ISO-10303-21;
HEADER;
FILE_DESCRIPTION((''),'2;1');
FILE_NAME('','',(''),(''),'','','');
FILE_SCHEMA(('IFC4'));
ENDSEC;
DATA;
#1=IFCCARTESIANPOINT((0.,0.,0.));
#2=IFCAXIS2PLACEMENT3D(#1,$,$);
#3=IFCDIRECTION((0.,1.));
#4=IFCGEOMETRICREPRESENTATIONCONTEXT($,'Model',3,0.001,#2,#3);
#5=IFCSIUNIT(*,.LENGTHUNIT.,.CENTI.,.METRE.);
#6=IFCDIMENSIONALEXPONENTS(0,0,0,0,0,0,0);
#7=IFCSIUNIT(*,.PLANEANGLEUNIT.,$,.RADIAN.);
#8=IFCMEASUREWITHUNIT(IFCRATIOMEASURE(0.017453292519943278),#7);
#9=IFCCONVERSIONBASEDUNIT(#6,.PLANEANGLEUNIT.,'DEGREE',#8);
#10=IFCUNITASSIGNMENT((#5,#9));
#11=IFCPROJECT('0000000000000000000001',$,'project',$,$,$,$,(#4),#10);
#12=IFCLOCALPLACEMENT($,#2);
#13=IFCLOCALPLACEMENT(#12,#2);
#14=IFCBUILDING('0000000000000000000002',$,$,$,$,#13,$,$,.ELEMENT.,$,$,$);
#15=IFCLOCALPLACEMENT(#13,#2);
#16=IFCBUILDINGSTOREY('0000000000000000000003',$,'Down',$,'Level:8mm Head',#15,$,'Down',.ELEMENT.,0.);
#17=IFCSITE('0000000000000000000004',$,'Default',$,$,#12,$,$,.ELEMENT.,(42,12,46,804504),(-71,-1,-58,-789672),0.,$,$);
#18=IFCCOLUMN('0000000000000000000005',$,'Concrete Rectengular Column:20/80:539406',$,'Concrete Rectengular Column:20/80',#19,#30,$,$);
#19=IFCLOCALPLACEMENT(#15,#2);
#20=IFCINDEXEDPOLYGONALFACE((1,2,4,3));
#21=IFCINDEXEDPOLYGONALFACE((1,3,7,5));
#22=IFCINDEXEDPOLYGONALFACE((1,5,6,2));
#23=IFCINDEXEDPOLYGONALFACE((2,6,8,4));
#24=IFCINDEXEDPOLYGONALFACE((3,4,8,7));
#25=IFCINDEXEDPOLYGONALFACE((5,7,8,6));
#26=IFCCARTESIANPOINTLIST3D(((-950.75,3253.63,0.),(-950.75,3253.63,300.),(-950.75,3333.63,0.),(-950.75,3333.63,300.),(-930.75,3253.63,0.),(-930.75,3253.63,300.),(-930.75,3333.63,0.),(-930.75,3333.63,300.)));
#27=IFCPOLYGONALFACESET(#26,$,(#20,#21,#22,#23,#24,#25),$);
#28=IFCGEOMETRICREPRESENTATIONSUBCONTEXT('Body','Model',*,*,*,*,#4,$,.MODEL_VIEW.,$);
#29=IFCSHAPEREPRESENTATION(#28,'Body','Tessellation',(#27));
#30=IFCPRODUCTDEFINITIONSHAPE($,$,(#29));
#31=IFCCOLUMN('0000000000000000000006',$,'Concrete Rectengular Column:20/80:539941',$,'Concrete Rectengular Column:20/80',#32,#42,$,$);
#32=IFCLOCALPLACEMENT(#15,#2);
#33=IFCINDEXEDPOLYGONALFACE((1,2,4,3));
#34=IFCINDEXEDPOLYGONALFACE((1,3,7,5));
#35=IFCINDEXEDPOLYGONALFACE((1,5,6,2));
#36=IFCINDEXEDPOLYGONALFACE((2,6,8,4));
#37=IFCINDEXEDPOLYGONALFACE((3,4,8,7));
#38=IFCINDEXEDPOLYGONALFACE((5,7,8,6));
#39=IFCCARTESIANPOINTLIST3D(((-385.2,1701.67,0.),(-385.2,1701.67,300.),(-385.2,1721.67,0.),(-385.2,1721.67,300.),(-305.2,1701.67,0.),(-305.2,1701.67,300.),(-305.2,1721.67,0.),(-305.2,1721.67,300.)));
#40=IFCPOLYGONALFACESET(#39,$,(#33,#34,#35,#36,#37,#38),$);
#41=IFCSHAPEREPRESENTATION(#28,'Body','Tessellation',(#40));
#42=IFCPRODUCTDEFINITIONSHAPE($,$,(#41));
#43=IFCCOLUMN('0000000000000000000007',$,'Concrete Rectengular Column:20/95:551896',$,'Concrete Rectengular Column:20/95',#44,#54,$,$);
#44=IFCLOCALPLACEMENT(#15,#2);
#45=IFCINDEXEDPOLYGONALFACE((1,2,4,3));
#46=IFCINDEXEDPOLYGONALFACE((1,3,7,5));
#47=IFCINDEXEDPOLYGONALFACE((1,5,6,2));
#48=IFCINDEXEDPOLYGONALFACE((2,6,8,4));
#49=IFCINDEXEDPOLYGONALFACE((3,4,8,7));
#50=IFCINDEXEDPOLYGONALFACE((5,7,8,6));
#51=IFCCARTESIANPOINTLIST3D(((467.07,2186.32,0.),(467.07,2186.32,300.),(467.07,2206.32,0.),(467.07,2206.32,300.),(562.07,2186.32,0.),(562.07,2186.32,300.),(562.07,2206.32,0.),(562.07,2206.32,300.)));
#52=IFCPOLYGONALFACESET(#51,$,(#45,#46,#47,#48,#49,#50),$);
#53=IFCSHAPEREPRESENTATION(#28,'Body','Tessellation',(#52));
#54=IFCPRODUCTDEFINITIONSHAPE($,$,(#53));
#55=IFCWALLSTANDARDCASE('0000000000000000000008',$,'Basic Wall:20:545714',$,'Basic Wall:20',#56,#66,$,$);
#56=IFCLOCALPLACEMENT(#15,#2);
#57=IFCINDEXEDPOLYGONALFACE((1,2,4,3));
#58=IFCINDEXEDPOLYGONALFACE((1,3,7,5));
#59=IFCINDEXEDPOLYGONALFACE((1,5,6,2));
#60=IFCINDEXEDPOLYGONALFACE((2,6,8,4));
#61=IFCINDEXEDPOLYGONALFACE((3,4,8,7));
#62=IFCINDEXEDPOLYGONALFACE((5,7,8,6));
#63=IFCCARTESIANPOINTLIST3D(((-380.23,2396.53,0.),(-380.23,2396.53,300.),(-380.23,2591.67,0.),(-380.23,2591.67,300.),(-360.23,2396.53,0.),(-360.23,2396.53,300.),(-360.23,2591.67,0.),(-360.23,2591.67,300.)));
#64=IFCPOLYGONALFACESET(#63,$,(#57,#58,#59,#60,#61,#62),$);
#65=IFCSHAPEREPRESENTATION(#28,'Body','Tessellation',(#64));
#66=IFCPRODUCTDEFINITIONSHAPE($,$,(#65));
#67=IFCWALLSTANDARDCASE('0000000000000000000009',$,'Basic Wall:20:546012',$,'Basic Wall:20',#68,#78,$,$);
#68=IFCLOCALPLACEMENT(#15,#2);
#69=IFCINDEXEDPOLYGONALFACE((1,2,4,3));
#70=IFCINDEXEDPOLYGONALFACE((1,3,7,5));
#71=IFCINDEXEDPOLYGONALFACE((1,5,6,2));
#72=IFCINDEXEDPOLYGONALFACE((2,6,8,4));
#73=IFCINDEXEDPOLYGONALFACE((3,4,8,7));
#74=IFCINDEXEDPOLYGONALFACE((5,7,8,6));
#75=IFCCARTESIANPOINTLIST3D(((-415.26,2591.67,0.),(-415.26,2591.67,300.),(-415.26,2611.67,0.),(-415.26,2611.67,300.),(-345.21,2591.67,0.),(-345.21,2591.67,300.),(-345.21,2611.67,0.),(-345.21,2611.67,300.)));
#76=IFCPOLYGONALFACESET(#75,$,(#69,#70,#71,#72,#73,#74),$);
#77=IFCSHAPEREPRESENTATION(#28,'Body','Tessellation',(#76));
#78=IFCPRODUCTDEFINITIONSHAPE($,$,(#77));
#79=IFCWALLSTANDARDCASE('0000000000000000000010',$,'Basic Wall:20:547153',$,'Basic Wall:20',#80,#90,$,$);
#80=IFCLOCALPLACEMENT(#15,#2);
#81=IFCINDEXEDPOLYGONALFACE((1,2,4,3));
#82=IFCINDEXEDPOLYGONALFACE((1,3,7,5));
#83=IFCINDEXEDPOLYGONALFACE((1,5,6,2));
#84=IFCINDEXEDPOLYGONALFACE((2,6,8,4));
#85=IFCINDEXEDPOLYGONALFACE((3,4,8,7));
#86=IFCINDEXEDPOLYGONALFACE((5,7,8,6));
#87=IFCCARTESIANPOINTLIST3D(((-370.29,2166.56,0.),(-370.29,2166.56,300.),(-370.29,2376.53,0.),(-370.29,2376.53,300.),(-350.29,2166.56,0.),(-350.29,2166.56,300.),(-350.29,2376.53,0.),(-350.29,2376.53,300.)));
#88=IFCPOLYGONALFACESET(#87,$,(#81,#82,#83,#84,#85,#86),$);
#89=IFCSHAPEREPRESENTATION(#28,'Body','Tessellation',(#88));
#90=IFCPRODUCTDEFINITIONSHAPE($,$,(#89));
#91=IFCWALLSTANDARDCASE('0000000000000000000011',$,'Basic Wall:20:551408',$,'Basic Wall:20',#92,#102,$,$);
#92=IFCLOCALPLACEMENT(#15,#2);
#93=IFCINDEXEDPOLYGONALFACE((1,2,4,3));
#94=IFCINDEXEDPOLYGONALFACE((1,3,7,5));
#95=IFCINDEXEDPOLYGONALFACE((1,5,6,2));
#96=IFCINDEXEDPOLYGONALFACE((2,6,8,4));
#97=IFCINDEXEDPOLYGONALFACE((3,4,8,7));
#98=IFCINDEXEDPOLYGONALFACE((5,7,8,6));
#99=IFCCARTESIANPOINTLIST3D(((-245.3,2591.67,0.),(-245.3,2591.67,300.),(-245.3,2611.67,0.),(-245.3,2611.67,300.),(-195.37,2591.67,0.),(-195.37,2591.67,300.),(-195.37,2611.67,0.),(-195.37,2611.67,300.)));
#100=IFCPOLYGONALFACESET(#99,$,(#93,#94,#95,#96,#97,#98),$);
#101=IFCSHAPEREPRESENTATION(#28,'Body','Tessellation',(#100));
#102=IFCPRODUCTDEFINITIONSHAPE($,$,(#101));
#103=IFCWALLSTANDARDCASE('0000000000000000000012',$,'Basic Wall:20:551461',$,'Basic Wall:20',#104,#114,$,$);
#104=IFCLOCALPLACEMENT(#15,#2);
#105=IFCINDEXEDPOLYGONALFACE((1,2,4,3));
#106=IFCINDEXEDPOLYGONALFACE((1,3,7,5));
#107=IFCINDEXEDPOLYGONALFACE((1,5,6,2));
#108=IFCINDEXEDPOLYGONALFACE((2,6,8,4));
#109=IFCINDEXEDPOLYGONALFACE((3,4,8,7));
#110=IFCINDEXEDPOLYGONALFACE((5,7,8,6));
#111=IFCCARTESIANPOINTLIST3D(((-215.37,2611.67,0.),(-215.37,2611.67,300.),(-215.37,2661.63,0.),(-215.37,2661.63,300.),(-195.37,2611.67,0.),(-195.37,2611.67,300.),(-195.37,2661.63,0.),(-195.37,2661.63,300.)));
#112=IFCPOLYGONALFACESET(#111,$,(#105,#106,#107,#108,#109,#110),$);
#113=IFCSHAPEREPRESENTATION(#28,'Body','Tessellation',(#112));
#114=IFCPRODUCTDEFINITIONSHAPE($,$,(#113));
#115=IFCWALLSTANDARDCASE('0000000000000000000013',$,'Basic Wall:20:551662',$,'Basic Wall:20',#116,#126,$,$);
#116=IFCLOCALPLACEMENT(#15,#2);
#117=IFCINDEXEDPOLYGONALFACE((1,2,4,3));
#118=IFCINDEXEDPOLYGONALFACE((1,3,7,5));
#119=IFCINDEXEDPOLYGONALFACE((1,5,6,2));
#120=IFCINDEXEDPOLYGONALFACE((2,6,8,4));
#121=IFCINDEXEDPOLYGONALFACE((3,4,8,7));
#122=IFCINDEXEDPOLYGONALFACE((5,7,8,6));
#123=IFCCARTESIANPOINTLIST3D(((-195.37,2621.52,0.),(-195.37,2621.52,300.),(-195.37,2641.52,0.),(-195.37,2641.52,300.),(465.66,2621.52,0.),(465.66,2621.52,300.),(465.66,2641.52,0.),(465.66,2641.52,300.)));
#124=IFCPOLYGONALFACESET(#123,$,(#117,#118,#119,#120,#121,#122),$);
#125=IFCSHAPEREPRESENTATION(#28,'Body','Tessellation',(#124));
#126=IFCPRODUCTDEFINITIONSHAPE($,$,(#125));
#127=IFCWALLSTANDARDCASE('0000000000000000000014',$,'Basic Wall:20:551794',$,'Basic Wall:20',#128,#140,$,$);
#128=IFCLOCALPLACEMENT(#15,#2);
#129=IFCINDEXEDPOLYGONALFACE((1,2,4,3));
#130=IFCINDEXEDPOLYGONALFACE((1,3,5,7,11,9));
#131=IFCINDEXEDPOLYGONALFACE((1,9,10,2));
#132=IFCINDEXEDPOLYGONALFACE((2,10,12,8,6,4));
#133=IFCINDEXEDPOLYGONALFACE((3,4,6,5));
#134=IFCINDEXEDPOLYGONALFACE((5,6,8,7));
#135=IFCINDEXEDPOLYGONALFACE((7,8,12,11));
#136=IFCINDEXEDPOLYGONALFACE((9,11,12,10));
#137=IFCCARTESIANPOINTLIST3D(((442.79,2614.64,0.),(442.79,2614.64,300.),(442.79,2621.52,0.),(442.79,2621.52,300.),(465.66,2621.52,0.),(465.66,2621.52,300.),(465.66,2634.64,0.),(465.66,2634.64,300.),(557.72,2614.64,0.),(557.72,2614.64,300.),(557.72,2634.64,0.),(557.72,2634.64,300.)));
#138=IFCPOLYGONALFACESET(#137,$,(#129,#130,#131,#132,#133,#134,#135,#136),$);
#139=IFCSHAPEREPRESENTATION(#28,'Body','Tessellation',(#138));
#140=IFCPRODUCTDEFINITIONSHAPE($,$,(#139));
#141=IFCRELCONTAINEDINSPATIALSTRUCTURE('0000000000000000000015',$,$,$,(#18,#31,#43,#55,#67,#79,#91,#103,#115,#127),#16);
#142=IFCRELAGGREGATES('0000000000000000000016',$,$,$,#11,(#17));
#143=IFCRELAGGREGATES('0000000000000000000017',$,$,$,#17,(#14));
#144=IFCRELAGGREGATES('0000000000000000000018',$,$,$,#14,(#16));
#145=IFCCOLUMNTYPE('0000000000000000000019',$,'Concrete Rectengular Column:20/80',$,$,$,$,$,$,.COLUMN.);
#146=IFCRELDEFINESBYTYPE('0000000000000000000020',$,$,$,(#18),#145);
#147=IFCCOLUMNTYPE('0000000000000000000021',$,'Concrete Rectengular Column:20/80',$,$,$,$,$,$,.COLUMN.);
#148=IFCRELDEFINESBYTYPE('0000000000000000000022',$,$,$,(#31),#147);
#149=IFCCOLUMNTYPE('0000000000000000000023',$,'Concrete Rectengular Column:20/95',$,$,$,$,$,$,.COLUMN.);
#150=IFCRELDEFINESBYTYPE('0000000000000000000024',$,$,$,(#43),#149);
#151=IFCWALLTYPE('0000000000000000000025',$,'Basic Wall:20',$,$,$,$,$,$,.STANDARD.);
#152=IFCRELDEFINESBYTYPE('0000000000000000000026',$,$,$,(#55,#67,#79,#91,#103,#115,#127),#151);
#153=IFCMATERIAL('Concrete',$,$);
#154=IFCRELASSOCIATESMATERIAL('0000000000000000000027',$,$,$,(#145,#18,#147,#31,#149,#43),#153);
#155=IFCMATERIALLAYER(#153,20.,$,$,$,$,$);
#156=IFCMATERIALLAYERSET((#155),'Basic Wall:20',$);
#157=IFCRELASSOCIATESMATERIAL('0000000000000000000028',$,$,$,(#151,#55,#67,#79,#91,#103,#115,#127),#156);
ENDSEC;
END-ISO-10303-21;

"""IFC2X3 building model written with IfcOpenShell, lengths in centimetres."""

from ifc_helpers import new_model, entity, si_unit, converted_unit, direction, frame, frame_2d, origin, place, context, subcontext, project, spatial, polyline, rectangle, extrude, clip, bounded_halfspace, source, transform, mapped, material, layer, layer_set, layer_usage, type_object, type_shapes, element, save


model = new_model("IFC2X3")

# Units and contexts
model_context = context("Model", 3, precision=0.001, world=origin(), true_north=direction((0.0, 1.0)))
body_context = subcontext(model_context, "Body", "Model", "MODEL_VIEW")
ifc_project = project(units=[si_unit("LENGTHUNIT", "METRE", prefix="CENTI"), converted_unit("PLANEANGLEUNIT", "DEGREE", entity("IfcRatioMeasure", 0.017453292519943278), si_unit("PLANEANGLEUNIT", "RADIAN"), dimensions=[0, 0, 0, 0, 0, 0, 0])], contexts=[model_context])

# Site, building, storey
site_placement = place(None, origin())
site = spatial("IfcSite", under=ifc_project, at=site_placement, Name="Default", CompositionType="ELEMENT", RefLatitude=(42, 12, 46, 804504), RefLongitude=(-71, -1, -58, -789672), RefElevation=0.0)
building_placement = place(site_placement, origin())
building = spatial("IfcBuilding", under=site, at=building_placement, CompositionType="ELEMENT")
storey_placement = place(building_placement, origin())
storey = spatial("IfcBuildingStorey", under=building, at=storey_placement, Name="Down", ObjectType="Level:8mm Head", LongName="Down", CompositionType="ELEMENT", Elevation=0.0)

# Columns
ifc_material = material(Name="Concrete")
column_type_1 = type_object("IfcColumnType", Name="Concrete Rectengular Column:20/80", PredefinedType="COLUMN", material=ifc_material)
shared_shape_1 = source(origin(), body_context, "Body", "SweptSolid", [
    extrude(rectangle(XDim=80.0, YDim=20.0, at=frame_2d((0.0, 0.0), x_axis=(1.0, 0.0))), frame((-940.75, 3293.63, 0.0), z_axis=(0.0, 0.0, 1.0), x_axis=(0.0, -1.0, 0.0)), (0.0, 0.0, 1.0), 300.0),
])
type_shapes(column_type_1, [shared_shape_1])
column_1_placement = place(storey_placement, origin())
element("IfcColumn", 1, at=column_1_placement, inside=storey, type_object=column_type_1, material=ifc_material, Name="Concrete Rectengular Column:20/80:539406", ObjectType="Concrete Rectengular Column:20/80", context=body_context, shape_type="MappedRepresentation", body=[
    mapped(shared_shape_1, transform((0.0, 0.0, 0.0), scale=1.0)),
])
column_type_2 = type_object("IfcColumnType", Name="Concrete Rectengular Column:20/80", PredefinedType="COLUMN", material=ifc_material)
shared_shape_2 = source(origin(), body_context, "Body", "SweptSolid", [
    extrude(rectangle(XDim=20.0, YDim=80.0, at=frame_2d((0.0, 0.0), x_axis=(1.0, 0.0))), frame((-345.2, 1711.67, 0.0), z_axis=(0.0, 0.0, 1.0), x_axis=(0.0, -1.0, 0.0)), (0.0, 0.0, 1.0), 300.0),
])
type_shapes(column_type_2, [shared_shape_2])
column_2_placement = place(storey_placement, origin())
element("IfcColumn", 2, at=column_2_placement, inside=storey, type_object=column_type_2, material=ifc_material, Name="Concrete Rectengular Column:20/80:539941", ObjectType="Concrete Rectengular Column:20/80", context=body_context, shape_type="MappedRepresentation", body=[
    mapped(shared_shape_2, transform((0.0, 0.0, 0.0), scale=1.0)),
])
column_type_3 = type_object("IfcColumnType", Name="Concrete Rectengular Column:20/95", PredefinedType="COLUMN", material=ifc_material)
shared_shape_3 = source(origin(), body_context, "Body", "SweptSolid", [
    extrude(rectangle(XDim=20.0, YDim=95.0, at=frame_2d((0.0, 0.0), x_axis=(1.0, 0.0))), frame((514.57, 2196.32, 0.0), z_axis=(0.0, 0.0, 1.0), x_axis=(0.0, -1.0, 0.0)), (0.0, 0.0, 1.0), 300.0),
])
type_shapes(column_type_3, [shared_shape_3])
column_3_placement = place(storey_placement, origin())
element("IfcColumn", 3, at=column_3_placement, inside=storey, type_object=column_type_3, material=ifc_material, Name="Concrete Rectengular Column:20/95:551896", ObjectType="Concrete Rectengular Column:20/95", context=body_context, shape_type="MappedRepresentation", body=[
    mapped(shared_shape_3, transform((0.0, 0.0, 0.0), scale=1.0)),
])

# Walls
ifc_layer = layer(ifc_material, 20.0)
ifc_layer_set = layer_set([ifc_layer], Name="Basic Wall:20")
ifc_layer_usage_1 = layer_usage(ifc_layer_set, "AXIS2", "POSITIVE", -10.0)
wall_type = type_object("IfcWallType", Name="Basic Wall:20", PredefinedType="STANDARD", material=ifc_layer_set)
wall_1_placement = place(storey_placement, frame((-370.23, 2396.53, 0.0), z_axis=(0.0, 0.0, 1.0), x_axis=(0.0, 1.0, 0.0)))
element("IfcWallStandardCase", 4, at=wall_1_placement, inside=storey, type_object=wall_type, material=ifc_layer_usage_1, Name="Basic Wall:20:545714", ObjectType="Basic Wall:20", context=body_context, shape_type="SweptSolid", body=[
    extrude(rectangle(XDim=195.15, YDim=20.0, at=frame_2d((97.57, 0.0), x_axis=(-1.0, 0.0))), origin(), (0.0, 0.0, 1.0), 300.0),
])
ifc_layer_usage_2 = layer_usage(ifc_layer_set, "AXIS2", "POSITIVE", -10.0)
wall_2_placement = place(storey_placement, frame((-345.21, 2601.67, 0.0), z_axis=(0.0, 0.0, 1.0), x_axis=(-1.0, 0.0, 0.0)))
element("IfcWallStandardCase", 5, at=wall_2_placement, inside=storey, type_object=wall_type, material=ifc_layer_usage_2, Name="Basic Wall:20:546012", ObjectType="Basic Wall:20", context=body_context, shape_type="SweptSolid", body=[
    extrude(rectangle(XDim=70.06, YDim=20.0, at=frame_2d((35.03, 0.0), x_axis=(-1.0, 0.0))), origin(), (0.0, 0.0, 1.0), 300.0),
])
ifc_layer_usage_3 = layer_usage(ifc_layer_set, "AXIS2", "POSITIVE", -10.0)
wall_3_placement = place(storey_placement, frame((-360.29, 2166.56, 0.0), z_axis=(0.0, 0.0, 1.0), x_axis=(0.0, 1.0, 0.0)))
element("IfcWallStandardCase", 6, at=wall_3_placement, inside=storey, type_object=wall_type, material=ifc_layer_usage_3, Name="Basic Wall:20:547153", ObjectType="Basic Wall:20", context=body_context, shape_type="SweptSolid", body=[
    extrude(rectangle(XDim=209.97, YDim=20.0, at=frame_2d((104.98, 0.0), x_axis=(-1.0, 0.0))), origin(), (0.0, 0.0, 1.0), 300.0),
])
ifc_layer_usage_4 = layer_usage(ifc_layer_set, "AXIS2", "POSITIVE", -10.0)
wall_4_placement = place(storey_placement, frame((-245.3, 2601.67, 0.0)))
element("IfcWallStandardCase", 7, at=wall_4_placement, inside=storey, type_object=wall_type, material=ifc_layer_usage_4, Name="Basic Wall:20:551408", ObjectType="Basic Wall:20", context=body_context, shape_type="SweptSolid", body=[
    extrude(rectangle(XDim=49.94, YDim=20.0, at=frame_2d((24.97, 0.0), x_axis=(-1.0, 0.0))), origin(), (0.0, 0.0, 1.0), 300.0),
])
ifc_layer_usage_5 = layer_usage(ifc_layer_set, "AXIS2", "POSITIVE", -10.0)
wall_5_placement = place(storey_placement, frame((-205.37, 2611.67, 0.0), z_axis=(0.0, 0.0, 1.0), x_axis=(0.0, 1.0, 0.0)))
element("IfcWallStandardCase", 8, at=wall_5_placement, inside=storey, type_object=wall_type, material=ifc_layer_usage_5, Name="Basic Wall:20:551461", ObjectType="Basic Wall:20", context=body_context, shape_type="SweptSolid", body=[
    extrude(rectangle(XDim=49.95, YDim=20.0, at=frame_2d((24.98, 0.0), x_axis=(-1.0, 0.0))), origin(), (0.0, 0.0, 1.0), 300.0),
])
ifc_layer_usage_6 = layer_usage(ifc_layer_set, "AXIS2", "NEGATIVE", 10.0)
wall_6_placement = place(storey_placement, frame((-195.37, 2631.52, 0.0)))
element("IfcWallStandardCase", 9, at=wall_6_placement, inside=storey, type_object=wall_type, material=ifc_layer_usage_6, Name="Basic Wall:20:551662", ObjectType="Basic Wall:20", context=body_context, shape_type="SweptSolid", body=[
    extrude(rectangle(XDim=661.03, YDim=20.0, at=frame_2d((330.51, 0.0), x_axis=(-1.0, 0.0))), origin(), (0.0, 0.0, 1.0), 300.0),
])
ifc_layer_usage_7 = layer_usage(ifc_layer_set, "AXIS2", "POSITIVE", -10.0)
wall_7_placement = place(storey_placement, frame((442.79, 2624.64, 0.0)))
element("IfcWallStandardCase", 10, at=wall_7_placement, inside=storey, type_object=wall_type, material=ifc_layer_usage_7, Name="Basic Wall:20:551794", ObjectType="Basic Wall:20", context=body_context, shape_type="Clipping", body=[
    clip(clip(extrude(rectangle(XDim=114.94, YDim=20.0, at=frame_2d((57.47, 0.0), x_axis=(-1.0, 0.0))), origin(), (0.0, 0.0, 1.0), 300.0), bounded_halfspace(frame((22.87, -3.12, 300.0), z_axis=(0.0, -1.0, 0.0), x_axis=(1.0, 0.0, 0.0)), True, frame((22.87, -3.12, 300.0), z_axis=(0.0, -1.0, 0.0), x_axis=(1.0, 0.0, 0.0)), polyline([(0.0, 0.0), (-22.87, 0.0), (-22.87, -20.0), (-22.87, -300.0), (0.0, -300.0), (0.0, 0.0)]))), bounded_halfspace(frame((22.87, -3.12, 0.0), z_axis=(1.0, 0.0, 0.0), x_axis=(0.0, 1.0, 0.0)), True, frame((22.87, -3.12, 0.0), z_axis=(1.0, 0.0, 0.0), x_axis=(0.0, 1.0, 0.0)), polyline([(0.0, 0.0), (13.12, 0.0), (13.12, 280.0), (13.12, 300.0), (0.0, 300.0), (0.0, 0.0)]))),
])

save(model, "model.ifc")
